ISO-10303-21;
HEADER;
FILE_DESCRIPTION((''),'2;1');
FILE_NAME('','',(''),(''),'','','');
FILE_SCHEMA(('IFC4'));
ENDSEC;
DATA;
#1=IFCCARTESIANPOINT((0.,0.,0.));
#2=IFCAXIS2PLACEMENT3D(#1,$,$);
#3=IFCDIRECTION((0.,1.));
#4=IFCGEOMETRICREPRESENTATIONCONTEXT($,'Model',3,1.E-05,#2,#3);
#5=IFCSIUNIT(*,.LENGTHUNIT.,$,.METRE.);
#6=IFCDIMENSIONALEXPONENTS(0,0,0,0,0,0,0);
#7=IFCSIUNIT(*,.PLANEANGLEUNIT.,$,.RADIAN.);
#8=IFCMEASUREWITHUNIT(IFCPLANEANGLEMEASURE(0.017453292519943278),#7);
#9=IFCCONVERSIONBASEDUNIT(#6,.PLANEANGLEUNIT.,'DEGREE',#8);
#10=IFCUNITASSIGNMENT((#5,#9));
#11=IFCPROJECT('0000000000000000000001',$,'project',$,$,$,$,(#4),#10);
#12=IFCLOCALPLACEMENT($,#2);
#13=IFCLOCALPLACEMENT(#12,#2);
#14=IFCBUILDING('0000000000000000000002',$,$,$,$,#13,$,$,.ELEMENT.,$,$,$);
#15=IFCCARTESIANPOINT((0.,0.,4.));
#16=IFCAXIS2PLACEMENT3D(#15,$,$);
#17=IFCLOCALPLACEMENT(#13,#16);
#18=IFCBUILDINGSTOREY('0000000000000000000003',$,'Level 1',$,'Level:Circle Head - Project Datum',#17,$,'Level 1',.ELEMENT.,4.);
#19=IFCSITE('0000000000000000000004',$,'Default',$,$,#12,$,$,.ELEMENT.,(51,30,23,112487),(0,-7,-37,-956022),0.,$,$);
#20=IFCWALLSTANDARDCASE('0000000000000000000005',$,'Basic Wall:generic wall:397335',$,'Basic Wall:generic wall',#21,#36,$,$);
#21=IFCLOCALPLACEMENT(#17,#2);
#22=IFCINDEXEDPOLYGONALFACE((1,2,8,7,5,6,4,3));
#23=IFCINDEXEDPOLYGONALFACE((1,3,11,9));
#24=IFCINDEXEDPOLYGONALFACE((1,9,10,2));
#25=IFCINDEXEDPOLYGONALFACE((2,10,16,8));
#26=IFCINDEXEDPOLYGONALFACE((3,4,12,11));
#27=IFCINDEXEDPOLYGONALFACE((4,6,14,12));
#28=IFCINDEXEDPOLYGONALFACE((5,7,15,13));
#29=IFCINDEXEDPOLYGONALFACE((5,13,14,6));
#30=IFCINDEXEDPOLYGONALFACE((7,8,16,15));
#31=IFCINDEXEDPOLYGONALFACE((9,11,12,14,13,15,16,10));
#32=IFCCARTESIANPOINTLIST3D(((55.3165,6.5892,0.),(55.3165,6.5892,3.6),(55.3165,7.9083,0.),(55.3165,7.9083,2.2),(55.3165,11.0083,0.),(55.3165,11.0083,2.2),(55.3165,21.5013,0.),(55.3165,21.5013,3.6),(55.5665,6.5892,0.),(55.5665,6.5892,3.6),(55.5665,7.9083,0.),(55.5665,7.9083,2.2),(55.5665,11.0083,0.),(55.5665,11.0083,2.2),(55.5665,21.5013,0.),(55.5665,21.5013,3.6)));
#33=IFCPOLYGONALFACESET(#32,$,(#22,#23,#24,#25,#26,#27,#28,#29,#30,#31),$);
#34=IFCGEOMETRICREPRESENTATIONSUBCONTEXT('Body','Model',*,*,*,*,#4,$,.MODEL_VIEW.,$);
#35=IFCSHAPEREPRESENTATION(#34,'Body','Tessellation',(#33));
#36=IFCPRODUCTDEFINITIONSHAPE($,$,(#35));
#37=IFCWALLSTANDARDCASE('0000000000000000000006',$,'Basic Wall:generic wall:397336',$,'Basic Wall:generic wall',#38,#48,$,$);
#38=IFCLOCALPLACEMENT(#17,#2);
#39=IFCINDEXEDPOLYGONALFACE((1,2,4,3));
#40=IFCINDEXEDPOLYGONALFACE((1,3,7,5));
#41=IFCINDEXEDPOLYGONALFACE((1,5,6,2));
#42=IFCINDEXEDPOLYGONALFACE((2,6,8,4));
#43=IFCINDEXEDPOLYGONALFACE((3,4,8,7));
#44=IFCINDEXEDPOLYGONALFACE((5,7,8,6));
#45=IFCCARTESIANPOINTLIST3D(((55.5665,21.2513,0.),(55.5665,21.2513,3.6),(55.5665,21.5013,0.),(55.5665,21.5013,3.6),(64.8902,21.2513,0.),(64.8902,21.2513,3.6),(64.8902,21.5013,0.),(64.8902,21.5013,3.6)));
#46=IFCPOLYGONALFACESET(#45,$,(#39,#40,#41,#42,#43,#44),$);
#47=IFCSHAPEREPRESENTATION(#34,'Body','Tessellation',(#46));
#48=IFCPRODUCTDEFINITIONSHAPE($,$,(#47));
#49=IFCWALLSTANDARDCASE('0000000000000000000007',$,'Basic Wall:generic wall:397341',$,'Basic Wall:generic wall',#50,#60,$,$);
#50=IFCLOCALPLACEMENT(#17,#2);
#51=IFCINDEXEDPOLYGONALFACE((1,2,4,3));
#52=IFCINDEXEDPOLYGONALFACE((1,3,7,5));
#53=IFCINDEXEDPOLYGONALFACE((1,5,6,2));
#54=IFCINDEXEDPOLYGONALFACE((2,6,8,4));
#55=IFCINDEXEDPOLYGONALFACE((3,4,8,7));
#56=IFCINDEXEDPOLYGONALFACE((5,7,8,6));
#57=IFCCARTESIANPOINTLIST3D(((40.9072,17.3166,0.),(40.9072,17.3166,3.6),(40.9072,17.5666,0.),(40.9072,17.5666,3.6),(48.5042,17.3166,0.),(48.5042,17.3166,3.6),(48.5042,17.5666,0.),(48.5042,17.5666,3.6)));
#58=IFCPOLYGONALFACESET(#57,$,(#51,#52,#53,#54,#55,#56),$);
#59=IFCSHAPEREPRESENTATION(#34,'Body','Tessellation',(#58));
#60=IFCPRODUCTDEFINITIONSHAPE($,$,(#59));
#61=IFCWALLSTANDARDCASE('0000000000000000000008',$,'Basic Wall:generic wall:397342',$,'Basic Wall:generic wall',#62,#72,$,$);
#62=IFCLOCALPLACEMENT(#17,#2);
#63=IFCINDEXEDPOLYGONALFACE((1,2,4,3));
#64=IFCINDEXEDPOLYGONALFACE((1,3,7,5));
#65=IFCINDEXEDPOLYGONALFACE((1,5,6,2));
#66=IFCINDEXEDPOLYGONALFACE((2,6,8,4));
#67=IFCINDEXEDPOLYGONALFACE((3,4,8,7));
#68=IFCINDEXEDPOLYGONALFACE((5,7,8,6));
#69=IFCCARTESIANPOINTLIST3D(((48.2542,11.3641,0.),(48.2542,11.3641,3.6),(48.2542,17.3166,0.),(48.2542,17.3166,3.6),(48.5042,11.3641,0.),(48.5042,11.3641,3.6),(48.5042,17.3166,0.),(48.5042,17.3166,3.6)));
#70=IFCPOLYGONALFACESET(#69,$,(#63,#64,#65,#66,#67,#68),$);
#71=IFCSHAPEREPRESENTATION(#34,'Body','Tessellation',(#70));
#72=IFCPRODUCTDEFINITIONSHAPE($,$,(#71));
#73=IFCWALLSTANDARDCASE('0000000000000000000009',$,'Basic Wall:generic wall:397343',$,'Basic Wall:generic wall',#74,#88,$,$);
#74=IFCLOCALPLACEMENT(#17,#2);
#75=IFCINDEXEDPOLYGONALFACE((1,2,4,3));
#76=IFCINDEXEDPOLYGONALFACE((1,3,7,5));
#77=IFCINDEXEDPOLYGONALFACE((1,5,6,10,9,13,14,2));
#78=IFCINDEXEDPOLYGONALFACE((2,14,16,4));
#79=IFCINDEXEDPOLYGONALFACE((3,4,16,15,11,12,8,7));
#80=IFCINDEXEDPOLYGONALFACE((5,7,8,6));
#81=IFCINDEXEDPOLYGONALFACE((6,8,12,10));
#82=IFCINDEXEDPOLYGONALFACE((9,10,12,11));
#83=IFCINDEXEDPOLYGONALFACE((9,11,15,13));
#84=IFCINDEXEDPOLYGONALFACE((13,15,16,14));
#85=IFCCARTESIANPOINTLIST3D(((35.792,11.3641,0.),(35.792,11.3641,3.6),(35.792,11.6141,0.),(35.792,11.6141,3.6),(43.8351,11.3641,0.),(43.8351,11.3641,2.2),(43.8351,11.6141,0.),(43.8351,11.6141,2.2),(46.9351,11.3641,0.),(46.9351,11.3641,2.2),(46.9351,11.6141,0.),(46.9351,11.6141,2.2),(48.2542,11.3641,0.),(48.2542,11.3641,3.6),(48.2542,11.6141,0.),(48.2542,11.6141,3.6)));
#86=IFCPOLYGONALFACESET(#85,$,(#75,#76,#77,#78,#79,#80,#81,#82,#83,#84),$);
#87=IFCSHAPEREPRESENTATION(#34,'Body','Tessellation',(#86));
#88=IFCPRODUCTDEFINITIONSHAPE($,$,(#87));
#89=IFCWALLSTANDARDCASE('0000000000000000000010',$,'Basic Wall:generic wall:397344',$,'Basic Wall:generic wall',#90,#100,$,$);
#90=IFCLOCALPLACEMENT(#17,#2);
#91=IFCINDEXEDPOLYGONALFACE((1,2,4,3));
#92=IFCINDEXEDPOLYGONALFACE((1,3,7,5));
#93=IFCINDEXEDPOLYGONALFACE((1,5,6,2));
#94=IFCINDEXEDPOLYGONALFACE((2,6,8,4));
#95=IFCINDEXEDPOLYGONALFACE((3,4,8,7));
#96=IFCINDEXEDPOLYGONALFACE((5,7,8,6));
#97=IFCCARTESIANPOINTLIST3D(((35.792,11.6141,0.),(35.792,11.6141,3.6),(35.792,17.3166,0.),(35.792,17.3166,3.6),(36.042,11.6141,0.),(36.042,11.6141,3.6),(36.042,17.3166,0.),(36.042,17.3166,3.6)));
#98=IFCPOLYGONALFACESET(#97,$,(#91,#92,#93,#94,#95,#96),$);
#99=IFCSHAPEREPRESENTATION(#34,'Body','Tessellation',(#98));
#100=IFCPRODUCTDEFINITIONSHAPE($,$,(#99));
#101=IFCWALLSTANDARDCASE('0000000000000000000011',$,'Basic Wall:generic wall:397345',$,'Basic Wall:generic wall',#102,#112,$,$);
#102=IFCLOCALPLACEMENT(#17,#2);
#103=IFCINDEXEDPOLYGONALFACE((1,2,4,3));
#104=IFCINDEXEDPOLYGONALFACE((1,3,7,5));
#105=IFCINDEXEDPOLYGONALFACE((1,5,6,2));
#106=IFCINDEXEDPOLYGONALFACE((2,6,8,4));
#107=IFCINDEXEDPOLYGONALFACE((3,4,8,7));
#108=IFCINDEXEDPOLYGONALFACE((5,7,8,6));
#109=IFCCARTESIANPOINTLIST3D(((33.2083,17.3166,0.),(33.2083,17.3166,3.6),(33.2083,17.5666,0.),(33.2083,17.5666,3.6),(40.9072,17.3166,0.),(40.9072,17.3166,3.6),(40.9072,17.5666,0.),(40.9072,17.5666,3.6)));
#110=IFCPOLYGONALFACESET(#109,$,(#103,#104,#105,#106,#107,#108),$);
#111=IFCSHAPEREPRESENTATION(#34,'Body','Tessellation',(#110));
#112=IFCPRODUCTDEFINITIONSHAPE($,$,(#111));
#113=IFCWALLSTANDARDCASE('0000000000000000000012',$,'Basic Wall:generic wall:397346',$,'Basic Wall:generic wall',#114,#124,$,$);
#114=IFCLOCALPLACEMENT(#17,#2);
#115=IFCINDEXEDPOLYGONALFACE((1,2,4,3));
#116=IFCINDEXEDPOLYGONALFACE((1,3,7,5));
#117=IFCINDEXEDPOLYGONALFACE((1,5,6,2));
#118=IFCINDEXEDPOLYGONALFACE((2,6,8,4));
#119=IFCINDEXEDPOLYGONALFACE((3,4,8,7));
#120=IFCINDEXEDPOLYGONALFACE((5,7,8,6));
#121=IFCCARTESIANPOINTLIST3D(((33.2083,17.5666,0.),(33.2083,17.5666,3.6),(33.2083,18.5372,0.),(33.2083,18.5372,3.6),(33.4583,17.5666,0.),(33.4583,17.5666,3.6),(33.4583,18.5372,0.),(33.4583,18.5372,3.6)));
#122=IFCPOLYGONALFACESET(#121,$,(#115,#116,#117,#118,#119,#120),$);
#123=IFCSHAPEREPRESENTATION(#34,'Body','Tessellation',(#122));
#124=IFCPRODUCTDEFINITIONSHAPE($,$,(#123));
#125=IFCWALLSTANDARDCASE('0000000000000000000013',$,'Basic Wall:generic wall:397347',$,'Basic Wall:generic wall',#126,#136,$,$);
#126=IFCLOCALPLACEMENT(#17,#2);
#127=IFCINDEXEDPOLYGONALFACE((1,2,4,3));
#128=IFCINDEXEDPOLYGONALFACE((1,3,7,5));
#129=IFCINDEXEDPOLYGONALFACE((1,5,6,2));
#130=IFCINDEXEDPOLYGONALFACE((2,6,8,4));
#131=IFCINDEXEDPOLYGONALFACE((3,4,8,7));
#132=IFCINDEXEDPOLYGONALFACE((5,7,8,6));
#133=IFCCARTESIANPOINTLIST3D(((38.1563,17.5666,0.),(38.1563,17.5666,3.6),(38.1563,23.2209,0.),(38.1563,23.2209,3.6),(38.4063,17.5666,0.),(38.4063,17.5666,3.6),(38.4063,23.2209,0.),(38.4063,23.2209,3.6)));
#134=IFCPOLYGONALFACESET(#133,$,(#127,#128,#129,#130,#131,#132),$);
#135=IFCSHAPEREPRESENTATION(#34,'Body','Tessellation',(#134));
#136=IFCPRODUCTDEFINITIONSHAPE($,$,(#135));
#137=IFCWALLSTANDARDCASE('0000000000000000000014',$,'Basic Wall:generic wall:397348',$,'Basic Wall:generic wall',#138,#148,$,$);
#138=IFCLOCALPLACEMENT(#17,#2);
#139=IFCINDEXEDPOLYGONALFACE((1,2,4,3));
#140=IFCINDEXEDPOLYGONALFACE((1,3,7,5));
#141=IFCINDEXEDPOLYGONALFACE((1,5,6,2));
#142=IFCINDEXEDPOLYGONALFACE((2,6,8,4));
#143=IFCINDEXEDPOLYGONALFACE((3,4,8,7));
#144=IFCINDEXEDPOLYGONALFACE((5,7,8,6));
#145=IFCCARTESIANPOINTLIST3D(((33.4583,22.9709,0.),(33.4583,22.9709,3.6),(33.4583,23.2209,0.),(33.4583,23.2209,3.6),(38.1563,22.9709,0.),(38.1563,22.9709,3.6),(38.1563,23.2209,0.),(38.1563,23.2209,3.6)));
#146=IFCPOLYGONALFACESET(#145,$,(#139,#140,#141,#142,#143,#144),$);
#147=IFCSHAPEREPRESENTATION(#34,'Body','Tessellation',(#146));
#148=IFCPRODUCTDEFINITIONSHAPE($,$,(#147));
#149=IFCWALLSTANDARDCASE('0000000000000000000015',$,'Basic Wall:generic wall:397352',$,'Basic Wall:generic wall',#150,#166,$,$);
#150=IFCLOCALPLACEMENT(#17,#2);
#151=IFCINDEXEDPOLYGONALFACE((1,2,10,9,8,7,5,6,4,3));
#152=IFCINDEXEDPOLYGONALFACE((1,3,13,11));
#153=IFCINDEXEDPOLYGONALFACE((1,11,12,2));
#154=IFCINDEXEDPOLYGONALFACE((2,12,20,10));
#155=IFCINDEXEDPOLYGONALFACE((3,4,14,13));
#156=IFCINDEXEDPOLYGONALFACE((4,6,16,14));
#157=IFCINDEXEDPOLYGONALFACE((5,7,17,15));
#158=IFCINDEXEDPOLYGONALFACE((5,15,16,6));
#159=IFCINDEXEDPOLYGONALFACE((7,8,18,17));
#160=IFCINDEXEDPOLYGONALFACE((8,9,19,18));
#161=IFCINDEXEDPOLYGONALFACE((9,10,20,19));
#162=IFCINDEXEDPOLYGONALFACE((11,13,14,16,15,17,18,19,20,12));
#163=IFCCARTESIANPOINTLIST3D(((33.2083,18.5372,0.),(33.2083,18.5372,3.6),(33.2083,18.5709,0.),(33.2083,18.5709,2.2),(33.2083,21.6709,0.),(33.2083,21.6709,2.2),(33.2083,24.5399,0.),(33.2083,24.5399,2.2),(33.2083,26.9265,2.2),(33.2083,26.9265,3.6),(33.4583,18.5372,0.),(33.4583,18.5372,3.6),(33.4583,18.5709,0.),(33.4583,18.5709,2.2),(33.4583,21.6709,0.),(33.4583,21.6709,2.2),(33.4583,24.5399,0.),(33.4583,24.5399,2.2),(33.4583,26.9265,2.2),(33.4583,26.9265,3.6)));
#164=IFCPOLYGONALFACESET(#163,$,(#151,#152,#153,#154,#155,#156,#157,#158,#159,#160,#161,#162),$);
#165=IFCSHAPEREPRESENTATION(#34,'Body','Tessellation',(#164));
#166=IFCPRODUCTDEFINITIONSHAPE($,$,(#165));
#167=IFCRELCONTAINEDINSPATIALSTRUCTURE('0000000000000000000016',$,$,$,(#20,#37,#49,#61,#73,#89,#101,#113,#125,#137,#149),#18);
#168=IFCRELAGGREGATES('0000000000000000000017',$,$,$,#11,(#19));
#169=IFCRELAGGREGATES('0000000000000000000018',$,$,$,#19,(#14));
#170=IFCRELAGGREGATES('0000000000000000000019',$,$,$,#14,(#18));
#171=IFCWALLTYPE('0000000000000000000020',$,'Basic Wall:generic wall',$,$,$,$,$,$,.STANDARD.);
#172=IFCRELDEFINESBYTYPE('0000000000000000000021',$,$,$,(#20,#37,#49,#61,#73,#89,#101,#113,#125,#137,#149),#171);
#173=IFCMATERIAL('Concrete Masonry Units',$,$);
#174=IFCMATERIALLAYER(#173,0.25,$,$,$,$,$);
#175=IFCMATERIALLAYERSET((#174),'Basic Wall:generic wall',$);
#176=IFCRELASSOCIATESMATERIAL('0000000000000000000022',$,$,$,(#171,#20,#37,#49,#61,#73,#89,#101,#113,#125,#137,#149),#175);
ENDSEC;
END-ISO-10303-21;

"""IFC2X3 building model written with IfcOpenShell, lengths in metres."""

from ifc_helpers import new_model, entity, si_unit, converted_unit, direction, frame, frame_2d, origin, place, context, subcontext, project, spatial, rectangle, extrude, material, layer, layer_set, layer_usage, type_object, element, save


model = new_model("IFC2X3")

# Units and contexts
model_context = context("Model", 3, precision=1e-05, world=origin(), true_north=direction((0.0, 1.0)))
body_context = subcontext(model_context, "Body", "Model", "MODEL_VIEW")
ifc_project = project(units=[si_unit("LENGTHUNIT", "METRE"), converted_unit("PLANEANGLEUNIT", "DEGREE", entity("IfcPlaneAngleMeasure", 0.017453292519943278), si_unit("PLANEANGLEUNIT", "RADIAN"), dimensions=[0, 0, 0, 0, 0, 0, 0])], contexts=[model_context])

# Site, building, storey
site_placement = place(None, origin())
site = spatial("IfcSite", under=ifc_project, at=site_placement, Name="Default", CompositionType="ELEMENT", RefLatitude=(51, 30, 23, 112487), RefLongitude=(0, -7, -37, -956022), RefElevation=0.0)
building_placement = place(site_placement, origin())
building = spatial("IfcBuilding", under=site, at=building_placement, CompositionType="ELEMENT")
storey_placement = place(building_placement, frame((0.0, 0.0, 4.0)))
storey = spatial("IfcBuildingStorey", under=building, at=storey_placement, Name="Level 1", ObjectType="Level:Circle Head - Project Datum", LongName="Level 1", CompositionType="ELEMENT", Elevation=4.0)

# Shared definitions
ifc_material = material(Name="Concrete Masonry Units")
ifc_layer = layer(ifc_material, 0.25)
ifc_layer_set = layer_set([ifc_layer], Name="Basic Wall:generic wall")
wall_type = type_object("IfcWallType", Name="Basic Wall:generic wall", PredefinedType="STANDARD", material=ifc_layer_set)

# Wall, opening
ifc_layer_usage_1 = layer_usage(ifc_layer_set, "AXIS2", "NEGATIVE", 0.125)
wall_1_placement = place(storey_placement, frame((55.4415, 21.5013, 0.0), z_axis=(0.0, 0.0, 1.0), x_axis=(0.0, -1.0, 0.0)))
wall_1 = element("IfcWallStandardCase", 1, at=wall_1_placement, inside=storey, type_object=wall_type, material=ifc_layer_usage_1, Name="Basic Wall:generic wall:397335", ObjectType="Basic Wall:generic wall", context=body_context, shape_type="SweptSolid", body=[
    extrude(rectangle(XDim=14.9121, YDim=0.25, at=frame_2d((7.4561, 0.0), x_axis=(1.0, 0.0))), origin(), (0.0, 0.0, 1.0), 3.6),
])
opening_1_placement = place(wall_1_placement, frame((10.4931, -0.125, 0.0)))
element("IfcOpeningElement", 2, at=opening_1_placement, cuts=wall_1, ObjectType="Opening", context=body_context, shape_type="SweptSolid", body=[
    extrude(rectangle(XDim=2.2, YDim=3.1, at=frame_2d((1.1, 1.55), x_axis=(1.0, 0.0))), frame((0.0, 0.0, 0.0), z_axis=(0.0, 1.0, 0.0), x_axis=(0.0, 0.0, 1.0)), (0.0, 0.0, 1.0), 0.25),
])

# Walls
ifc_layer_usage_2 = layer_usage(ifc_layer_set, "AXIS2", "NEGATIVE", 0.125)
wall_2_placement = place(storey_placement, frame((64.8902, 21.3763, 0.0), z_axis=(0.0, 0.0, 1.0), x_axis=(-1.0, 0.0, 0.0)))
element("IfcWallStandardCase", 3, at=wall_2_placement, inside=storey, type_object=wall_type, material=ifc_layer_usage_2, Name="Basic Wall:generic wall:397336", ObjectType="Basic Wall:generic wall", context=body_context, shape_type="SweptSolid", body=[
    extrude(rectangle(XDim=9.3237, YDim=0.25, at=frame_2d((4.6618, 0.0), x_axis=(-1.0, 0.0))), origin(), (0.0, 0.0, 1.0), 3.6),
])
ifc_layer_usage_3 = layer_usage(ifc_layer_set, "AXIS2", "NEGATIVE", 0.125)
wall_3_placement = place(storey_placement, frame((40.9072, 17.4416, 0.0)))
element("IfcWallStandardCase", 4, at=wall_3_placement, inside=storey, type_object=wall_type, material=ifc_layer_usage_3, Name="Basic Wall:generic wall:397341", ObjectType="Basic Wall:generic wall", context=body_context, shape_type="SweptSolid", body=[
    extrude(rectangle(XDim=7.597, YDim=0.25, at=frame_2d((3.7985, 0.0), x_axis=(-1.0, 0.0))), origin(), (0.0, 0.0, 1.0), 3.6),
])
ifc_layer_usage_4 = layer_usage(ifc_layer_set, "AXIS2", "NEGATIVE", 0.125)
wall_4_placement = place(storey_placement, frame((48.3792, 17.3166, 0.0), z_axis=(0.0, 0.0, 1.0), x_axis=(0.0, -1.0, 0.0)))
element("IfcWallStandardCase", 5, at=wall_4_placement, inside=storey, type_object=wall_type, material=ifc_layer_usage_4, Name="Basic Wall:generic wall:397342", ObjectType="Basic Wall:generic wall", context=body_context, shape_type="SweptSolid", body=[
    extrude(rectangle(XDim=5.9526, YDim=0.25, at=frame_2d((2.9763, 0.0), x_axis=(-1.0, 0.0))), origin(), (0.0, 0.0, 1.0), 3.6),
])

# Wall, opening
ifc_layer_usage_5 = layer_usage(ifc_layer_set, "AXIS2", "NEGATIVE", 0.125)
wall_5_placement = place(storey_placement, frame((48.2542, 11.4891, 0.0), z_axis=(0.0, 0.0, 1.0), x_axis=(-1.0, 0.0, 0.0)))
wall_5 = element("IfcWallStandardCase", 6, at=wall_5_placement, inside=storey, type_object=wall_type, material=ifc_layer_usage_5, Name="Basic Wall:generic wall:397343", ObjectType="Basic Wall:generic wall", context=body_context, shape_type="SweptSolid", body=[
    extrude(rectangle(XDim=12.4622, YDim=0.25, at=frame_2d((6.2311, 0.0), x_axis=(-1.0, 0.0))), origin(), (0.0, 0.0, 1.0), 3.6),
])
opening_2_placement = place(wall_5_placement, frame((4.419, 0.125, 0.0)))
element("IfcOpeningElement", 7, at=opening_2_placement, cuts=wall_5, ObjectType="Opening", context=body_context, shape_type="SweptSolid", body=[
    extrude(rectangle(XDim=2.2, YDim=3.1, at=frame_2d((1.1, 1.55), x_axis=(1.0, 0.0))), frame((0.0, 0.0, 0.0), z_axis=(0.0, -1.0, 0.0), x_axis=(0.0, 0.0, 1.0)), (0.0, 0.0, 1.0), 0.25),
])

# Walls
ifc_layer_usage_6 = layer_usage(ifc_layer_set, "AXIS2", "NEGATIVE", 0.125)
wall_6_placement = place(storey_placement, frame((35.917, 11.6141, 0.0), z_axis=(0.0, 0.0, 1.0), x_axis=(0.0, 1.0, 0.0)))
element("IfcWallStandardCase", 8, at=wall_6_placement, inside=storey, type_object=wall_type, material=ifc_layer_usage_6, Name="Basic Wall:generic wall:397344", ObjectType="Basic Wall:generic wall", context=body_context, shape_type="SweptSolid", body=[
    extrude(rectangle(XDim=5.7026, YDim=0.25, at=frame_2d((2.8513, 0.0), x_axis=(-1.0, 0.0))), origin(), (0.0, 0.0, 1.0), 3.6),
])
ifc_layer_usage_7 = layer_usage(ifc_layer_set, "AXIS2", "NEGATIVE", 0.125)
wall_7_placement = place(storey_placement, frame((33.2083, 17.4416, 0.0)))
element("IfcWallStandardCase", 9, at=wall_7_placement, inside=storey, type_object=wall_type, material=ifc_layer_usage_7, Name="Basic Wall:generic wall:397345", ObjectType="Basic Wall:generic wall", context=body_context, shape_type="SweptSolid", body=[
    extrude(rectangle(XDim=7.6989, YDim=0.25, at=frame_2d((3.8494, 0.0), x_axis=(-1.0, 0.0))), origin(), (0.0, 0.0, 1.0), 3.6),
])
ifc_layer_usage_8 = layer_usage(ifc_layer_set, "AXIS2", "NEGATIVE", 0.125)
wall_8_placement = place(storey_placement, frame((33.3333, 18.5372, 0.0), z_axis=(0.0, 0.0, 1.0), x_axis=(0.0, -1.0, 0.0)))
element("IfcWallStandardCase", 10, at=wall_8_placement, inside=storey, type_object=wall_type, material=ifc_layer_usage_8, Name="Basic Wall:generic wall:397346", ObjectType="Basic Wall:generic wall", context=body_context, shape_type="SweptSolid", body=[
    extrude(rectangle(XDim=0.9706, YDim=0.25, at=frame_2d((0.4853, 0.0), x_axis=(-1.0, 0.0))), origin(), (0.0, 0.0, 1.0), 3.6),
])
ifc_layer_usage_9 = layer_usage(ifc_layer_set, "AXIS2", "NEGATIVE", 0.125)
wall_9_placement = place(storey_placement, frame((38.2813, 17.5666, 0.0), z_axis=(0.0, 0.0, 1.0), x_axis=(0.0, 1.0, 0.0)))
element("IfcWallStandardCase", 11, at=wall_9_placement, inside=storey, type_object=wall_type, material=ifc_layer_usage_9, Name="Basic Wall:generic wall:397347", ObjectType="Basic Wall:generic wall", context=body_context, shape_type="SweptSolid", body=[
    extrude(rectangle(XDim=5.6542, YDim=0.25, at=frame_2d((2.8271, 0.0), x_axis=(-1.0, 0.0))), origin(), (0.0, 0.0, 1.0), 3.6),
])
ifc_layer_usage_10 = layer_usage(ifc_layer_set, "AXIS2", "NEGATIVE", 0.125)
wall_10_placement = place(storey_placement, frame((33.4583, 23.0959, 0.0)))
element("IfcWallStandardCase", 12, at=wall_10_placement, inside=storey, type_object=wall_type, material=ifc_layer_usage_10, Name="Basic Wall:generic wall:397348", ObjectType="Basic Wall:generic wall", context=body_context, shape_type="SweptSolid", body=[
    extrude(rectangle(XDim=4.698, YDim=0.25, at=frame_2d((2.349, 0.0), x_axis=(-1.0, 0.0))), origin(), (0.0, 0.0, 1.0), 3.6),
])

# Wall, openings
ifc_layer_usage_11 = layer_usage(ifc_layer_set, "AXIS2", "NEGATIVE", 0.125)
wall_11_placement = place(storey_placement, frame((33.3333, 18.5372, 0.0), z_axis=(0.0, 0.0, 1.0), x_axis=(0.0, 1.0, 0.0)))
wall_11 = element("IfcWallStandardCase", 13, at=wall_11_placement, inside=storey, type_object=wall_type, material=ifc_layer_usage_11, Name="Basic Wall:generic wall:397352", ObjectType="Basic Wall:generic wall", context=body_context, shape_type="SweptSolid", body=[
    extrude(rectangle(XDim=8.3893, YDim=0.25, at=frame_2d((4.1946, 0.0), x_axis=(-1.0, 0.0))), origin(), (0.0, 0.0, 1.0), 3.6),
])
opening_3_placement = place(wall_11_placement, frame((3.1337, 0.125, 0.0)))
element("IfcOpeningElement", 14, at=opening_3_placement, cuts=wall_11, ObjectType="Opening", context=body_context, shape_type="SweptSolid", body=[
    extrude(rectangle(XDim=2.2, YDim=3.1, at=frame_2d((1.1, 1.55), x_axis=(1.0, 0.0))), frame((0.0, 0.0, 0.0), z_axis=(0.0, -1.0, 0.0), x_axis=(0.0, 0.0, 1.0)), (0.0, 0.0, 1.0), 0.25),
])
opening_4_placement = place(wall_11_placement, frame((9.1027, 0.125, 0.0)))
element("IfcOpeningElement", 15, at=opening_4_placement, cuts=wall_11, ObjectType="Opening", context=body_context, shape_type="SweptSolid", body=[
    extrude(rectangle(XDim=2.2, YDim=3.1, at=frame_2d((1.1, 1.55), x_axis=(1.0, 0.0))), frame((0.0, 0.0, 0.0), z_axis=(0.0, -1.0, 0.0), x_axis=(0.0, 0.0, 1.0)), (0.0, 0.0, 1.0), 0.25),
])

save(model, "model.ifc")
